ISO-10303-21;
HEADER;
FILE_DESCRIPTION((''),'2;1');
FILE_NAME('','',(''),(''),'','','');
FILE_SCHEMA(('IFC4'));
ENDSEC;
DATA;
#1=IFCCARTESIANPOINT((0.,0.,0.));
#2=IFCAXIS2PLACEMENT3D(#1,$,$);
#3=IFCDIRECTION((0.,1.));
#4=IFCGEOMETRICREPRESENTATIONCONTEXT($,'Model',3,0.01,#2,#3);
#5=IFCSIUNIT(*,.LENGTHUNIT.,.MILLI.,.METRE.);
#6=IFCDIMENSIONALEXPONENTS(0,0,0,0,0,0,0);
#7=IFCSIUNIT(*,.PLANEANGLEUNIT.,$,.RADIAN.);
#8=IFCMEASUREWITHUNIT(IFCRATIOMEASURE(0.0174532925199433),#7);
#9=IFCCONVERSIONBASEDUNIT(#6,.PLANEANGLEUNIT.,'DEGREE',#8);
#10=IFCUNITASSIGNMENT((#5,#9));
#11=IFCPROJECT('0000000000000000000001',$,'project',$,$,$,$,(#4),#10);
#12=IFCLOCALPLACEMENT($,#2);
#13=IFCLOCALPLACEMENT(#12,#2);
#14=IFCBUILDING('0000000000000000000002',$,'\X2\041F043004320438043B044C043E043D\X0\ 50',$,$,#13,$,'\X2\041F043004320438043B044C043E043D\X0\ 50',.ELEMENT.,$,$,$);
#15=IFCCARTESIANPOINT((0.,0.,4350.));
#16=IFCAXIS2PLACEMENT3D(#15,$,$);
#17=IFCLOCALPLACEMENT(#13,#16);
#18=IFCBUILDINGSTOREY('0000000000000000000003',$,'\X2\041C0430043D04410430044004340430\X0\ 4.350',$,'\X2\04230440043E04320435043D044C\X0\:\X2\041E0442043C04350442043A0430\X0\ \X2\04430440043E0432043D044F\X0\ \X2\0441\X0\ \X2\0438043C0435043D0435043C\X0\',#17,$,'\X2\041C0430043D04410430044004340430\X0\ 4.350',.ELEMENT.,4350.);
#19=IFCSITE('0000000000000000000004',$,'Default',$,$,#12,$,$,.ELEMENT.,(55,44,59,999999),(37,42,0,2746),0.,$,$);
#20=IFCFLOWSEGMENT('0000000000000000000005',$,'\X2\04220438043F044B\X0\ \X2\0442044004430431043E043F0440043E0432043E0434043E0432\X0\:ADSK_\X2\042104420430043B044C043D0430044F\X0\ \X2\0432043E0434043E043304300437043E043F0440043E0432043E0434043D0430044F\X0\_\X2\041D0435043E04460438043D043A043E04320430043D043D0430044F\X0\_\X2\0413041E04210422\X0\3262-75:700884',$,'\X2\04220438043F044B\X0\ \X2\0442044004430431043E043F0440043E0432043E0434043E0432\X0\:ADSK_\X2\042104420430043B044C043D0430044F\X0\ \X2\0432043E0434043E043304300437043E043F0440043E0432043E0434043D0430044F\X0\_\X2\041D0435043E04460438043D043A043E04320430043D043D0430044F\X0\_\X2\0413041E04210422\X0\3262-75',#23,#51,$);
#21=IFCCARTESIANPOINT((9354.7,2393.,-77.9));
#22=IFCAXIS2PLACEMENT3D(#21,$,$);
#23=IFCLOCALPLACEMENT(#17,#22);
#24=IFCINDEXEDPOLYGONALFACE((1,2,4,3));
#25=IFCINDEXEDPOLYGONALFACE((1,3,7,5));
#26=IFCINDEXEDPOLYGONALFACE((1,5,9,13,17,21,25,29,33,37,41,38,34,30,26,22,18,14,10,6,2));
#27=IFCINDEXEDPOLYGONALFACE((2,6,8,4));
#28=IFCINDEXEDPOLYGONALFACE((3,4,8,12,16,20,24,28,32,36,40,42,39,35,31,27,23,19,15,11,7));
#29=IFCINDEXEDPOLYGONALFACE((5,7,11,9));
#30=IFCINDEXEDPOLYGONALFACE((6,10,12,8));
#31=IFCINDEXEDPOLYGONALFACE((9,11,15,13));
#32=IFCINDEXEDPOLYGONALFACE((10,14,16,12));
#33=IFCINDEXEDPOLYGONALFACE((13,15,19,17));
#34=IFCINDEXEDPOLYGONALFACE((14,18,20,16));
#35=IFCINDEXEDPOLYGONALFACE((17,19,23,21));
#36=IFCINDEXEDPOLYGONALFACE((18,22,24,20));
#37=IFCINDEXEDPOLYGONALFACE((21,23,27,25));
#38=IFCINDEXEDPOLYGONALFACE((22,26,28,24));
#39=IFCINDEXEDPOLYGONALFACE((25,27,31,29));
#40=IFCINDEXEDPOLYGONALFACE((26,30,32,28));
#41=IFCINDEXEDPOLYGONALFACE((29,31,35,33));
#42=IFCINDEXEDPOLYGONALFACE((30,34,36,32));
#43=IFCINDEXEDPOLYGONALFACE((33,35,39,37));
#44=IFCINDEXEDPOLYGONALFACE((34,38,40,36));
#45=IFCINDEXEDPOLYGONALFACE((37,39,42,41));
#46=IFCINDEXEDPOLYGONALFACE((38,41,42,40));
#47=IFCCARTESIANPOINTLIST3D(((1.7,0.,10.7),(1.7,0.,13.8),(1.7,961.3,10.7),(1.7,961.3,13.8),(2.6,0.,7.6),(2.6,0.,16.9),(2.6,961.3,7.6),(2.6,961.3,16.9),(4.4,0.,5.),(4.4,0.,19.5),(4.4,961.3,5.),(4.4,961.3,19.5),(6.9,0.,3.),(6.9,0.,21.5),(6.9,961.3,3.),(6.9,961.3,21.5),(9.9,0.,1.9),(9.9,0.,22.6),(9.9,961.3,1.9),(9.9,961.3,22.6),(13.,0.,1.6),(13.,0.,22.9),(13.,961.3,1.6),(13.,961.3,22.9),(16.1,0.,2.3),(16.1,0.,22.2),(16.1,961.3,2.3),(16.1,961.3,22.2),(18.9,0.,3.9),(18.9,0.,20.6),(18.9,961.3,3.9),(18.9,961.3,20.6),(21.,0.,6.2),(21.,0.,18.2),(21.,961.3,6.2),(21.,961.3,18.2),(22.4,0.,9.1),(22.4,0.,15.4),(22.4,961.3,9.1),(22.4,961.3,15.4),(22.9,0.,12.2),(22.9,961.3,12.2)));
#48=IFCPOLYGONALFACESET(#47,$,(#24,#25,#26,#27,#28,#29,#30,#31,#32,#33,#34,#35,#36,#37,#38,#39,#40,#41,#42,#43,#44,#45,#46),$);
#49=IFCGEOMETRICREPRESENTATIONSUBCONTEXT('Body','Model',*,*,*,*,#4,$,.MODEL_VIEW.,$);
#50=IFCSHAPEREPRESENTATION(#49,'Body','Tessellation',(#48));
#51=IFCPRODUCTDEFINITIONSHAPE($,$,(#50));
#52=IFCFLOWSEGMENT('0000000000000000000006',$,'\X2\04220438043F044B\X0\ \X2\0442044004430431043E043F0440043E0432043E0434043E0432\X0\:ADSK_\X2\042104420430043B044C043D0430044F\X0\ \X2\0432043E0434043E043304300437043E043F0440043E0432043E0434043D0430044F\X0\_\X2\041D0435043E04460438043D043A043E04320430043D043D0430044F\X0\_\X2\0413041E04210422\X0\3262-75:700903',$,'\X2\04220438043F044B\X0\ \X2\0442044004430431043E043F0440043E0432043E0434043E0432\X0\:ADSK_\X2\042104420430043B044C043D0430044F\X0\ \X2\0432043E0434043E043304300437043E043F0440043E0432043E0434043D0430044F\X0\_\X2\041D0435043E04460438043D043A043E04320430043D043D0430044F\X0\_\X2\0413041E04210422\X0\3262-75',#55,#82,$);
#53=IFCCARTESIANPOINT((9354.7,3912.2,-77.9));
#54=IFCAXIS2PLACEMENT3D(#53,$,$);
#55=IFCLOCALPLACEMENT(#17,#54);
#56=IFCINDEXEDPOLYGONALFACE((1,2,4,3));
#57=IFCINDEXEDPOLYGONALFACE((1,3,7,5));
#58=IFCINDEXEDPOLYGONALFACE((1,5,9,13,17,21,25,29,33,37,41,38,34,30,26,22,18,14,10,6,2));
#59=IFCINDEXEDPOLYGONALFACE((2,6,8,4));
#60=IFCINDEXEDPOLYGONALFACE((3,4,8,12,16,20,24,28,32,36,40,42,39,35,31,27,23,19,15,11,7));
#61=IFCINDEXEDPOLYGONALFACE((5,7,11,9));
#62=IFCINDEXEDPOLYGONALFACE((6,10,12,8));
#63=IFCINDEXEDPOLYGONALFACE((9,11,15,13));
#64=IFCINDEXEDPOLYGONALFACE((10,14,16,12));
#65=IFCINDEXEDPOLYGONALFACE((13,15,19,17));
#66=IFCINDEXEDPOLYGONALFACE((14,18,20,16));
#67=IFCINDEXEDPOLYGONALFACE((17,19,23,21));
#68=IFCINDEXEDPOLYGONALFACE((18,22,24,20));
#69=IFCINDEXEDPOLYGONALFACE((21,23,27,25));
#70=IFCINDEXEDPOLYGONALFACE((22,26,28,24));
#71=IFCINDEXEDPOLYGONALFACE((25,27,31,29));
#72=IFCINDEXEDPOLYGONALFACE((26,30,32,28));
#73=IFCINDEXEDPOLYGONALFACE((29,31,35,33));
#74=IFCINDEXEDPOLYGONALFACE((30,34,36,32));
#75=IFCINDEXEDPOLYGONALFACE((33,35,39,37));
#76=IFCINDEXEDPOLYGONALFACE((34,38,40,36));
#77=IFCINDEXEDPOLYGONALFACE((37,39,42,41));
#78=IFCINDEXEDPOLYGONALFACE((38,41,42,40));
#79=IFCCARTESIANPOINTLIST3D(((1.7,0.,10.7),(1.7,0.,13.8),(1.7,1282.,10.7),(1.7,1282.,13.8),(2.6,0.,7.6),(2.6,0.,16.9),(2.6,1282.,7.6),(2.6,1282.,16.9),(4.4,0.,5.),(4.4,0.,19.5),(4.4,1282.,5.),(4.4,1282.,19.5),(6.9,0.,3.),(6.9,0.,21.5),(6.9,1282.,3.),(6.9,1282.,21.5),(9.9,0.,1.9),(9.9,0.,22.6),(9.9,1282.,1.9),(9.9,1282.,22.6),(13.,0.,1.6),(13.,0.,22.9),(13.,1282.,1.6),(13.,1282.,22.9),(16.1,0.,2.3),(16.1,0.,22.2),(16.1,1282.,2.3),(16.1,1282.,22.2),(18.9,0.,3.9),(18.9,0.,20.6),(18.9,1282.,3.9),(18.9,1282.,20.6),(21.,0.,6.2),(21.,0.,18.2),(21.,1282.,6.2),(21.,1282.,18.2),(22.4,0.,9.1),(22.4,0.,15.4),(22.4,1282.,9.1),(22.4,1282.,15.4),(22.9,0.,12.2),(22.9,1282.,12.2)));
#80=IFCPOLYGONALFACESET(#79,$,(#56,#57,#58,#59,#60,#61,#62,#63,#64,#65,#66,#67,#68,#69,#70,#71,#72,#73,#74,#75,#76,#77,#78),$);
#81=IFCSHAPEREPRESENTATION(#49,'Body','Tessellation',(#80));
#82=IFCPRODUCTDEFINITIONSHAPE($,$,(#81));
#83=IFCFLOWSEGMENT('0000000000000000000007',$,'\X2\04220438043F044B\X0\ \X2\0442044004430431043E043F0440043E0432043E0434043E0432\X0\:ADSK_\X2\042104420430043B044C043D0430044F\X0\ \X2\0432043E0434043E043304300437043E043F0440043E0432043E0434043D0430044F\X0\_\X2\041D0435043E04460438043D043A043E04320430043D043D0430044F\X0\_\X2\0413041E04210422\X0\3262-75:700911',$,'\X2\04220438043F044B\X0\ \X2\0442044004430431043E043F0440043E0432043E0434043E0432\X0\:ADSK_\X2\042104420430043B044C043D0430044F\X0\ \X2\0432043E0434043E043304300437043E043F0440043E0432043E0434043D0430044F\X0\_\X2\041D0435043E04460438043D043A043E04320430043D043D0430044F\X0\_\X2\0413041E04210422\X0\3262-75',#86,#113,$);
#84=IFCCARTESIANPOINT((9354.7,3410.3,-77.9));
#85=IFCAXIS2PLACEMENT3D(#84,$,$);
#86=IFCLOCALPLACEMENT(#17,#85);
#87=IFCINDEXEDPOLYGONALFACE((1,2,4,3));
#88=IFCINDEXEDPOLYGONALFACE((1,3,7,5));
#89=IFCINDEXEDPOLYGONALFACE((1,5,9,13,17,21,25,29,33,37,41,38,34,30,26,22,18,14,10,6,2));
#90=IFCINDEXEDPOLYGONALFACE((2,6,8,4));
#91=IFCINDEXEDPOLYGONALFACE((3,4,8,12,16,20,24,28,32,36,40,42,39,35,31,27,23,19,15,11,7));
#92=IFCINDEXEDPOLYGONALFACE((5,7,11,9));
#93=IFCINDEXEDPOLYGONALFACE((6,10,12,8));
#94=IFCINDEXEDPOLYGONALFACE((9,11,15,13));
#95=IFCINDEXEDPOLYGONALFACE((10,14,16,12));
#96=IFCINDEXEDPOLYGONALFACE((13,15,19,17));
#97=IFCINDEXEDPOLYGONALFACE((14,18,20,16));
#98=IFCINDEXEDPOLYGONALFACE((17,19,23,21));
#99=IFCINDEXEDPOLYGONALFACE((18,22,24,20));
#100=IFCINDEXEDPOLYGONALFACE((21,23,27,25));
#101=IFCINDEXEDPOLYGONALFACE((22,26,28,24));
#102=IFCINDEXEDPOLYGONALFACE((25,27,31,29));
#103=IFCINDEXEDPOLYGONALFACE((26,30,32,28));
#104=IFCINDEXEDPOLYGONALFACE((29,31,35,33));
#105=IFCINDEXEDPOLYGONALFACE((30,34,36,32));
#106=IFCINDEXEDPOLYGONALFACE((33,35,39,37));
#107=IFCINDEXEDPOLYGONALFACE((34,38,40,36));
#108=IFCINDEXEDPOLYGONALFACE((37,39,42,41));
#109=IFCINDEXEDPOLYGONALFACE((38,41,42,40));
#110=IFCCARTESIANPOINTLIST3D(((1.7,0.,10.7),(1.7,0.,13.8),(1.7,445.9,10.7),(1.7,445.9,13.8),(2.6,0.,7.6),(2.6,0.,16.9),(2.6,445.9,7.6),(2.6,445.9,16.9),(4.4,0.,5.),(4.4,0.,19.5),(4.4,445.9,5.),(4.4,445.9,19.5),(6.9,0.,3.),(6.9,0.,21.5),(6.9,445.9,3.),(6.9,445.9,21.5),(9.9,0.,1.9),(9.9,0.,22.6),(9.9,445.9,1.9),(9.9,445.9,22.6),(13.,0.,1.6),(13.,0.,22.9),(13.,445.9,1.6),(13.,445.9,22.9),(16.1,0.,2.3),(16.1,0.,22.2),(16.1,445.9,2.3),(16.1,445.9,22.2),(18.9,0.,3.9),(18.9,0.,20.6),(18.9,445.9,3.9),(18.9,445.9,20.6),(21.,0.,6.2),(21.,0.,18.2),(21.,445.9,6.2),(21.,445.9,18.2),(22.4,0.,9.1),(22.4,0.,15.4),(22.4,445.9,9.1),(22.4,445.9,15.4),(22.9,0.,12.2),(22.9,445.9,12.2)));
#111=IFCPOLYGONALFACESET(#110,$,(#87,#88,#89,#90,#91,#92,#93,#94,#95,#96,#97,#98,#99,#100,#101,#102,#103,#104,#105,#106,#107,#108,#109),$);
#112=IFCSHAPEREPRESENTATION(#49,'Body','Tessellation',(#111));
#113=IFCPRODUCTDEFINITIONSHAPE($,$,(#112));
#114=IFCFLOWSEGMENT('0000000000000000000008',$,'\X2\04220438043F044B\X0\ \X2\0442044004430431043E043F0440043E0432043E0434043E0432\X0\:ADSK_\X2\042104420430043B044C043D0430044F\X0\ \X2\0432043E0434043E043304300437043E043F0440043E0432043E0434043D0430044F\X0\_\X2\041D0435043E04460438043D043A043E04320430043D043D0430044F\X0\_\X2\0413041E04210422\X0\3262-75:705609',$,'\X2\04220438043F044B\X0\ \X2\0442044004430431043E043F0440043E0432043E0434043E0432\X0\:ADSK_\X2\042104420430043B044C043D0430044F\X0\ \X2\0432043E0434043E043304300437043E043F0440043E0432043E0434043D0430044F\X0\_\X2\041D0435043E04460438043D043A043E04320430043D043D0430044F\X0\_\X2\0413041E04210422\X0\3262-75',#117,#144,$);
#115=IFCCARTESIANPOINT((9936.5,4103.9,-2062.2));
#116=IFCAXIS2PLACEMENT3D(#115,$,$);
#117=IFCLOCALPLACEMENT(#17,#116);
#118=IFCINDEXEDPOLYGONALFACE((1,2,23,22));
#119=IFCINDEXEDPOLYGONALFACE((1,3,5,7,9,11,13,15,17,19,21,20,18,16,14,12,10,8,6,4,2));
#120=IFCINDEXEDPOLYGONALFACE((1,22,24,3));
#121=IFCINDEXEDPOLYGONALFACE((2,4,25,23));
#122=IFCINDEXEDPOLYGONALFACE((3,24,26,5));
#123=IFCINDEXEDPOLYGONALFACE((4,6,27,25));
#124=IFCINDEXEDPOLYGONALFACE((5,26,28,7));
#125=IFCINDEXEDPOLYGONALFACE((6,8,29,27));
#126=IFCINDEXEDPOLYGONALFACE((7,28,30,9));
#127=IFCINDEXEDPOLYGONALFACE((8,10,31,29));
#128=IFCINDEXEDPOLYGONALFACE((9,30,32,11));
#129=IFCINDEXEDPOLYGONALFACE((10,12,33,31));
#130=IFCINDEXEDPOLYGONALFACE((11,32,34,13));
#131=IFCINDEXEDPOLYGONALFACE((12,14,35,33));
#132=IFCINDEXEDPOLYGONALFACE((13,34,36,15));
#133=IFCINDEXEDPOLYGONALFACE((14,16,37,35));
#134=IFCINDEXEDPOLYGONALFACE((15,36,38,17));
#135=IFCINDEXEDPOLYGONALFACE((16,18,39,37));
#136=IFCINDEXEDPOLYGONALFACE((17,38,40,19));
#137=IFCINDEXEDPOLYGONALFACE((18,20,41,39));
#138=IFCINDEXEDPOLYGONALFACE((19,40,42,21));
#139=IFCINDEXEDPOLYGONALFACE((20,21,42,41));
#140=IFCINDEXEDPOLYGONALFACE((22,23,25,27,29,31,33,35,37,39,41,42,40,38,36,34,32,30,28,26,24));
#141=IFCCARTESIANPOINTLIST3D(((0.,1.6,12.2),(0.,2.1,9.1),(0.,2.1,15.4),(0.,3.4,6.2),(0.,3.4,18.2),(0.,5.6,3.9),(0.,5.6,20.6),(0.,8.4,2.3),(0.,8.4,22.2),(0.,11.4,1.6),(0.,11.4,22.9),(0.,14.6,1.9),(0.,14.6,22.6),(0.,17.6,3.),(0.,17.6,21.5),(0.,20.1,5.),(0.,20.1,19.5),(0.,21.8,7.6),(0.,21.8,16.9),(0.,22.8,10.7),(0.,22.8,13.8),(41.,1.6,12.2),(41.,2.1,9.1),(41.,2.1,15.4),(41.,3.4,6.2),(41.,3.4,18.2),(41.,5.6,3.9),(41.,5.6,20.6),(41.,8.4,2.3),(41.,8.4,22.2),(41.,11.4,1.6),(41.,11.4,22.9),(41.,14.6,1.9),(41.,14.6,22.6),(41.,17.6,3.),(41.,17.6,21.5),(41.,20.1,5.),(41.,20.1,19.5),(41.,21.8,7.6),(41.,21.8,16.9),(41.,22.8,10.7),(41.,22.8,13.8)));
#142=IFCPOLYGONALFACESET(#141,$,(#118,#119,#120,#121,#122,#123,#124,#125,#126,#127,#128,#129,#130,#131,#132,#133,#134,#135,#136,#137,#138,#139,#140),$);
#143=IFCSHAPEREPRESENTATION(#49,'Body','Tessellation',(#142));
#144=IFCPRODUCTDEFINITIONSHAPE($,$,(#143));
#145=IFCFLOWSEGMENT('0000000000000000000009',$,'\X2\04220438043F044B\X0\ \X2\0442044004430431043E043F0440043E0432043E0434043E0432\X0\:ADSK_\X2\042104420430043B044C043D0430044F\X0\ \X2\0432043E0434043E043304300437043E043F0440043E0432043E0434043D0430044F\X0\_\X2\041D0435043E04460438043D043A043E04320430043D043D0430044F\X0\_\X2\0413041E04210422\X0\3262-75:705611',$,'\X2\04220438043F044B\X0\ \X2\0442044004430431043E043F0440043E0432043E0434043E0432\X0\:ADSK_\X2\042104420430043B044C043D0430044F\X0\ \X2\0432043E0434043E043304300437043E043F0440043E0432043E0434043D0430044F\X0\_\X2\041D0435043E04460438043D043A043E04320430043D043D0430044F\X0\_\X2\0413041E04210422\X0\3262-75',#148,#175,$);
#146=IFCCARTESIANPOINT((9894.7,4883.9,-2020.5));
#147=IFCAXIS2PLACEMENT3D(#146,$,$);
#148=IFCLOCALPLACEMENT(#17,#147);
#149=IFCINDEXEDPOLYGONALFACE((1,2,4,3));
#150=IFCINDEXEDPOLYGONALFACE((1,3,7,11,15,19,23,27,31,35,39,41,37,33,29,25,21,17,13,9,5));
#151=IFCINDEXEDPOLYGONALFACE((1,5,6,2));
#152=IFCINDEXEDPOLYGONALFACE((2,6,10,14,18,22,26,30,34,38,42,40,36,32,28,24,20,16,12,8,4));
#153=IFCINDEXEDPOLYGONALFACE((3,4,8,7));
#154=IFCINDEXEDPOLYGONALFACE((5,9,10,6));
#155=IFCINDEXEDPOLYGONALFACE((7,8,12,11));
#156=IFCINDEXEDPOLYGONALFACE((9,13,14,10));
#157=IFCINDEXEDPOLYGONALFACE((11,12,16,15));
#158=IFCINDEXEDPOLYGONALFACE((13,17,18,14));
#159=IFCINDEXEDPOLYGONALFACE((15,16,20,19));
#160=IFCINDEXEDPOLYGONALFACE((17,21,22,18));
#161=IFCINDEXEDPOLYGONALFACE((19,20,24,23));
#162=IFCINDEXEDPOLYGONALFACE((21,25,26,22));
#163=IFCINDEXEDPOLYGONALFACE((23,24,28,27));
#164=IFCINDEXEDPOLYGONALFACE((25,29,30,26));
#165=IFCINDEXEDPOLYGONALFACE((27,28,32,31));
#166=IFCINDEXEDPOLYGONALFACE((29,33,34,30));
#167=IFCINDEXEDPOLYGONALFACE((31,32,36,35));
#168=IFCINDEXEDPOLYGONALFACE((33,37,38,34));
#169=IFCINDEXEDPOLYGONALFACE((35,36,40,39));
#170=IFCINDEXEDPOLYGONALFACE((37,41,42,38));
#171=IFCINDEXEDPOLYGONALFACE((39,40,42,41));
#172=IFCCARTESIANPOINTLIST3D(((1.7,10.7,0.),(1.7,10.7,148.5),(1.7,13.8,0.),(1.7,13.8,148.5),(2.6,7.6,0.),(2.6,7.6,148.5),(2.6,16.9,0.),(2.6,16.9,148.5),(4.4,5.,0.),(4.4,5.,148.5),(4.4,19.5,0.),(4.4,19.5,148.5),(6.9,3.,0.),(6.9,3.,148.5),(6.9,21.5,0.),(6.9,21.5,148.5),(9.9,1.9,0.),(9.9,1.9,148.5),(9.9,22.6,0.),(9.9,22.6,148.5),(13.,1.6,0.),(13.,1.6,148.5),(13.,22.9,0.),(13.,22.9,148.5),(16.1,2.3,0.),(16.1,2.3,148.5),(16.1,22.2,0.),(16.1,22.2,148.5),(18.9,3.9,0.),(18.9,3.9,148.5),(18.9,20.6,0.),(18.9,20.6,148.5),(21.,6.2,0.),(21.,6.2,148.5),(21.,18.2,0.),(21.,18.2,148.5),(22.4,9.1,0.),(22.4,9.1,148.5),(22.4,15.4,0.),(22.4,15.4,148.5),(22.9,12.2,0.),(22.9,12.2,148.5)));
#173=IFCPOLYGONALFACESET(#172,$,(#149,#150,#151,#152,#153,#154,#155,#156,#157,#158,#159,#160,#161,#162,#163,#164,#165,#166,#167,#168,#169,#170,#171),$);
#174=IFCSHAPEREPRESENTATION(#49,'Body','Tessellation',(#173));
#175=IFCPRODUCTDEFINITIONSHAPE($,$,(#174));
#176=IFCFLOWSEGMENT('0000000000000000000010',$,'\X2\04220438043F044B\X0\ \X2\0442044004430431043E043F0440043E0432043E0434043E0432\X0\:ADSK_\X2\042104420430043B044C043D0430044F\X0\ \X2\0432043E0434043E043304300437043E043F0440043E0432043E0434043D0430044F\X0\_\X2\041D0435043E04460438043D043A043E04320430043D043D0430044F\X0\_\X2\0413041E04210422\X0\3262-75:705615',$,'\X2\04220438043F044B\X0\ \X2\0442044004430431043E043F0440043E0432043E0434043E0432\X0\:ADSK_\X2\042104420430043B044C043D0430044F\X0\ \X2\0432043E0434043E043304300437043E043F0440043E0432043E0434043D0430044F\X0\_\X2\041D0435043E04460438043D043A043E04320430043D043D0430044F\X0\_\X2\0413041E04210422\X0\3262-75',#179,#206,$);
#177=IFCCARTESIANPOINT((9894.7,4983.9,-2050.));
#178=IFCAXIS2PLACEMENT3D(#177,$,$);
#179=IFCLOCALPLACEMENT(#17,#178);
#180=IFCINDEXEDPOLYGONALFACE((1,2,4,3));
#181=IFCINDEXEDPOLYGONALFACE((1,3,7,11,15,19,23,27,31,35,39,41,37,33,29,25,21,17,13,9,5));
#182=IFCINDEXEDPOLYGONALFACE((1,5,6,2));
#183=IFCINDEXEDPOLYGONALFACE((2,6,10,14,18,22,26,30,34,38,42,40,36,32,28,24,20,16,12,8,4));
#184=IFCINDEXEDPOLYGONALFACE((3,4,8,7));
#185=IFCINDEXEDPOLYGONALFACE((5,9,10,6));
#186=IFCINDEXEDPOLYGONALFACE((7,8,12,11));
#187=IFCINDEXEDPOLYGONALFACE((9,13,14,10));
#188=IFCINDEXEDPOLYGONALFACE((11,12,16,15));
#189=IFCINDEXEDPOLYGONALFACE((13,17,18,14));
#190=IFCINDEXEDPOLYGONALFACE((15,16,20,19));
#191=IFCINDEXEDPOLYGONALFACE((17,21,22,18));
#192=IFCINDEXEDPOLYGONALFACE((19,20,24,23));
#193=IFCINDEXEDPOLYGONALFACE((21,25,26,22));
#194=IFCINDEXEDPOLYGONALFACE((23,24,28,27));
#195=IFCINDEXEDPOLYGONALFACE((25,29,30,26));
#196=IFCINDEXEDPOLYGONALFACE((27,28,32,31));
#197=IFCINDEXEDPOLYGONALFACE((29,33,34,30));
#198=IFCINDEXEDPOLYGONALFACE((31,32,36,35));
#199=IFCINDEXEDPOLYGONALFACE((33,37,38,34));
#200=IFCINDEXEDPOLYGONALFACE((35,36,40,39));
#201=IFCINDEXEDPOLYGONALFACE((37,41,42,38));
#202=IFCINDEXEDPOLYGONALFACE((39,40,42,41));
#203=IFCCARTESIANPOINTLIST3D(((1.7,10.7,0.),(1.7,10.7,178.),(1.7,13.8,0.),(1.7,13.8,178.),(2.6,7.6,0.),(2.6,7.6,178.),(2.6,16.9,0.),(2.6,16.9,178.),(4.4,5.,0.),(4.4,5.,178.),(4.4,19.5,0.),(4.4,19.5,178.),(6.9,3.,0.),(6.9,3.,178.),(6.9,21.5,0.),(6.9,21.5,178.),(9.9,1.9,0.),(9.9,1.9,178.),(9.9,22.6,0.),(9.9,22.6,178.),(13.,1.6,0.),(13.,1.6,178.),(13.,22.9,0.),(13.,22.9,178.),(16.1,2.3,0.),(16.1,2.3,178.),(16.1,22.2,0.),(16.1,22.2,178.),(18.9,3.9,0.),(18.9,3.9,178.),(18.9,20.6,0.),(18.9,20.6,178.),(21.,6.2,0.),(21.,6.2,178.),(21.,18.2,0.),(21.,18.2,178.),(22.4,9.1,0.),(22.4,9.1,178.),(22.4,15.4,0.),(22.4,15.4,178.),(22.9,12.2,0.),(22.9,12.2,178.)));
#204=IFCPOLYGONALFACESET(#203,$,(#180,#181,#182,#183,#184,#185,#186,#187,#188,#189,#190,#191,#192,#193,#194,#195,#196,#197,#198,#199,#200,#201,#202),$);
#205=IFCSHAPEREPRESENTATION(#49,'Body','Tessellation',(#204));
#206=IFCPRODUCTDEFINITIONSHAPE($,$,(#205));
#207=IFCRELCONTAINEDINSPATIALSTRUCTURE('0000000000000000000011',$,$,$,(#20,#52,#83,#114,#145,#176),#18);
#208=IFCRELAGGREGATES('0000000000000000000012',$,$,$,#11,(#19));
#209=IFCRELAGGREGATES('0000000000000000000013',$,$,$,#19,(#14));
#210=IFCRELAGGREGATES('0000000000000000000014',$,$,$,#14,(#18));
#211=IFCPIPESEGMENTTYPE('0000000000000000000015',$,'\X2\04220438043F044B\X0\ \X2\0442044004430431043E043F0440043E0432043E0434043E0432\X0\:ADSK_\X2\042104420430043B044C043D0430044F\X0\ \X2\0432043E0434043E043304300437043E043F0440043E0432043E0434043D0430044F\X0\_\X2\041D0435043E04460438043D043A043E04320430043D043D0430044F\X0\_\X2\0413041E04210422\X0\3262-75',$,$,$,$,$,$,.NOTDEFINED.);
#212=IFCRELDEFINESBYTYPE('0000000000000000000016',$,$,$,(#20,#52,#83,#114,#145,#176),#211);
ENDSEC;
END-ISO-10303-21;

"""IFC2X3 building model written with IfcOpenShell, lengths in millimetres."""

from ifc_helpers import new_model, entity, si_unit, converted_unit, direction, frame, origin, origin_2d_with_axis, place, context, subcontext, project, spatial, circle, extrude, type_object, element, save


model = new_model("IFC2X3")

# Units and contexts
model_context = context("Model", 3, precision=0.01, world=origin(), true_north=direction((0.0, 1.0)))
body_context = subcontext(model_context, "Body", "Model", "MODEL_VIEW")
ifc_project = project(units=[si_unit("LENGTHUNIT", "METRE", prefix="MILLI"), converted_unit("PLANEANGLEUNIT", "DEGREE", entity("IfcRatioMeasure", 0.0174532925199433), si_unit("PLANEANGLEUNIT", "RADIAN"), dimensions=[0, 0, 0, 0, 0, 0, 0])], contexts=[model_context])

# Site, building, storey
site_placement = place(None, origin())
site = spatial("IfcSite", under=ifc_project, at=site_placement, Name="Default", CompositionType="ELEMENT", RefLatitude=(55, 44, 59, 999999), RefLongitude=(37, 42, 0, 2746), RefElevation=0.0)
building_placement = place(site_placement, origin())
building = spatial("IfcBuilding", under=site, at=building_placement, Name="Павильон 50", LongName="Павильон 50", CompositionType="ELEMENT")
storey_placement = place(building_placement, frame((0.0, 0.0, 4350.0)))
storey = spatial("IfcBuildingStorey", under=building, at=storey_placement, Name="Мансарда 4.350", ObjectType="Уровень:Отметка уровня с именем", LongName="Мансарда 4.350", CompositionType="ELEMENT", Elevation=4350.0)

# Flow segments
pipe_segment_type = type_object("IfcPipeSegmentType", Name="Типы трубопроводов:ADSK_Стальная водогазопроводная_Неоцинкованная_ГОСТ3262-75", PredefinedType="NOTDEFINED")
flow_segment_1_placement = place(storey_placement, frame((9354.7, 2393.0, -77.9)))
element("IfcFlowSegment", 1, at=flow_segment_1_placement, inside=storey, type_object=pipe_segment_type, Name="Типы трубопроводов:ADSK_Стальная водогазопроводная_Неоцинкованная_ГОСТ3262-75:700884", ObjectType="Типы трубопроводов:ADSK_Стальная водогазопроводная_Неоцинкованная_ГОСТ3262-75", context=body_context, shape_type="SweptSolid", body=[
    extrude(circle(Radius=10.7, at=origin_2d_with_axis()), frame((12.2, 0.0, 12.2), z_axis=(0.0, 1.0, 0.0), x_axis=(1.0, 0.0, 0.0)), (0.0, 0.0, 1.0), 961.3),
])
flow_segment_2_placement = place(storey_placement, frame((9354.7, 3912.2, -77.9)))
element("IfcFlowSegment", 2, at=flow_segment_2_placement, inside=storey, type_object=pipe_segment_type, Name="Типы трубопроводов:ADSK_Стальная водогазопроводная_Неоцинкованная_ГОСТ3262-75:700903", ObjectType="Типы трубопроводов:ADSK_Стальная водогазопроводная_Неоцинкованная_ГОСТ3262-75", context=body_context, shape_type="SweptSolid", body=[
    extrude(circle(Radius=10.7, at=origin_2d_with_axis()), frame((12.2, 0.0, 12.2), z_axis=(0.0, 1.0, 0.0), x_axis=(1.0, 0.0, 0.0)), (0.0, 0.0, 1.0), 1282.0),
])
flow_segment_3_placement = place(storey_placement, frame((9354.7, 3410.3, -77.9)))
element("IfcFlowSegment", 3, at=flow_segment_3_placement, inside=storey, type_object=pipe_segment_type, Name="Типы трубопроводов:ADSK_Стальная водогазопроводная_Неоцинкованная_ГОСТ3262-75:700911", ObjectType="Типы трубопроводов:ADSK_Стальная водогазопроводная_Неоцинкованная_ГОСТ3262-75", context=body_context, shape_type="SweptSolid", body=[
    extrude(circle(Radius=10.7, at=origin_2d_with_axis()), frame((12.2, 0.0, 12.2), z_axis=(0.0, 1.0, 0.0), x_axis=(1.0, 0.0, 0.0)), (0.0, 0.0, 1.0), 445.9),
])
flow_segment_4_placement = place(storey_placement, frame((9936.5, 4103.9, -2062.2)))
element("IfcFlowSegment", 4, at=flow_segment_4_placement, inside=storey, type_object=pipe_segment_type, Name="Типы трубопроводов:ADSK_Стальная водогазопроводная_Неоцинкованная_ГОСТ3262-75:705609", ObjectType="Типы трубопроводов:ADSK_Стальная водогазопроводная_Неоцинкованная_ГОСТ3262-75", context=body_context, shape_type="SweptSolid", body=[
    extrude(circle(Radius=10.7, at=origin_2d_with_axis()), frame((0.0, 12.2, 12.2), z_axis=(1.0, 0.0, 0.0), x_axis=(0.0, -1.0, 0.0)), (0.0, 0.0, 1.0), 41.0),
])
flow_segment_5_placement = place(storey_placement, frame((9894.7, 4883.9, -2020.5)))
element("IfcFlowSegment", 5, at=flow_segment_5_placement, inside=storey, type_object=pipe_segment_type, Name="Типы трубопроводов:ADSK_Стальная водогазопроводная_Неоцинкованная_ГОСТ3262-75:705611", ObjectType="Типы трубопроводов:ADSK_Стальная водогазопроводная_Неоцинкованная_ГОСТ3262-75", context=body_context, shape_type="SweptSolid", body=[
    extrude(circle(Radius=10.7, at=origin_2d_with_axis()), frame((12.2, 12.2, 0.0)), (0.0, 0.0, 1.0), 148.5),
])
flow_segment_6_placement = place(storey_placement, frame((9894.7, 4983.9, -2050.0)))
element("IfcFlowSegment", 6, at=flow_segment_6_placement, inside=storey, type_object=pipe_segment_type, Name="Типы трубопроводов:ADSK_Стальная водогазопроводная_Неоцинкованная_ГОСТ3262-75:705615", ObjectType="Типы трубопроводов:ADSK_Стальная водогазопроводная_Неоцинкованная_ГОСТ3262-75", context=body_context, shape_type="SweptSolid", body=[
    extrude(circle(Radius=10.7, at=origin_2d_with_axis()), frame((12.2, 12.2, 0.0)), (0.0, 0.0, 1.0), 178.0),
])

save(model, "model.ifc")
